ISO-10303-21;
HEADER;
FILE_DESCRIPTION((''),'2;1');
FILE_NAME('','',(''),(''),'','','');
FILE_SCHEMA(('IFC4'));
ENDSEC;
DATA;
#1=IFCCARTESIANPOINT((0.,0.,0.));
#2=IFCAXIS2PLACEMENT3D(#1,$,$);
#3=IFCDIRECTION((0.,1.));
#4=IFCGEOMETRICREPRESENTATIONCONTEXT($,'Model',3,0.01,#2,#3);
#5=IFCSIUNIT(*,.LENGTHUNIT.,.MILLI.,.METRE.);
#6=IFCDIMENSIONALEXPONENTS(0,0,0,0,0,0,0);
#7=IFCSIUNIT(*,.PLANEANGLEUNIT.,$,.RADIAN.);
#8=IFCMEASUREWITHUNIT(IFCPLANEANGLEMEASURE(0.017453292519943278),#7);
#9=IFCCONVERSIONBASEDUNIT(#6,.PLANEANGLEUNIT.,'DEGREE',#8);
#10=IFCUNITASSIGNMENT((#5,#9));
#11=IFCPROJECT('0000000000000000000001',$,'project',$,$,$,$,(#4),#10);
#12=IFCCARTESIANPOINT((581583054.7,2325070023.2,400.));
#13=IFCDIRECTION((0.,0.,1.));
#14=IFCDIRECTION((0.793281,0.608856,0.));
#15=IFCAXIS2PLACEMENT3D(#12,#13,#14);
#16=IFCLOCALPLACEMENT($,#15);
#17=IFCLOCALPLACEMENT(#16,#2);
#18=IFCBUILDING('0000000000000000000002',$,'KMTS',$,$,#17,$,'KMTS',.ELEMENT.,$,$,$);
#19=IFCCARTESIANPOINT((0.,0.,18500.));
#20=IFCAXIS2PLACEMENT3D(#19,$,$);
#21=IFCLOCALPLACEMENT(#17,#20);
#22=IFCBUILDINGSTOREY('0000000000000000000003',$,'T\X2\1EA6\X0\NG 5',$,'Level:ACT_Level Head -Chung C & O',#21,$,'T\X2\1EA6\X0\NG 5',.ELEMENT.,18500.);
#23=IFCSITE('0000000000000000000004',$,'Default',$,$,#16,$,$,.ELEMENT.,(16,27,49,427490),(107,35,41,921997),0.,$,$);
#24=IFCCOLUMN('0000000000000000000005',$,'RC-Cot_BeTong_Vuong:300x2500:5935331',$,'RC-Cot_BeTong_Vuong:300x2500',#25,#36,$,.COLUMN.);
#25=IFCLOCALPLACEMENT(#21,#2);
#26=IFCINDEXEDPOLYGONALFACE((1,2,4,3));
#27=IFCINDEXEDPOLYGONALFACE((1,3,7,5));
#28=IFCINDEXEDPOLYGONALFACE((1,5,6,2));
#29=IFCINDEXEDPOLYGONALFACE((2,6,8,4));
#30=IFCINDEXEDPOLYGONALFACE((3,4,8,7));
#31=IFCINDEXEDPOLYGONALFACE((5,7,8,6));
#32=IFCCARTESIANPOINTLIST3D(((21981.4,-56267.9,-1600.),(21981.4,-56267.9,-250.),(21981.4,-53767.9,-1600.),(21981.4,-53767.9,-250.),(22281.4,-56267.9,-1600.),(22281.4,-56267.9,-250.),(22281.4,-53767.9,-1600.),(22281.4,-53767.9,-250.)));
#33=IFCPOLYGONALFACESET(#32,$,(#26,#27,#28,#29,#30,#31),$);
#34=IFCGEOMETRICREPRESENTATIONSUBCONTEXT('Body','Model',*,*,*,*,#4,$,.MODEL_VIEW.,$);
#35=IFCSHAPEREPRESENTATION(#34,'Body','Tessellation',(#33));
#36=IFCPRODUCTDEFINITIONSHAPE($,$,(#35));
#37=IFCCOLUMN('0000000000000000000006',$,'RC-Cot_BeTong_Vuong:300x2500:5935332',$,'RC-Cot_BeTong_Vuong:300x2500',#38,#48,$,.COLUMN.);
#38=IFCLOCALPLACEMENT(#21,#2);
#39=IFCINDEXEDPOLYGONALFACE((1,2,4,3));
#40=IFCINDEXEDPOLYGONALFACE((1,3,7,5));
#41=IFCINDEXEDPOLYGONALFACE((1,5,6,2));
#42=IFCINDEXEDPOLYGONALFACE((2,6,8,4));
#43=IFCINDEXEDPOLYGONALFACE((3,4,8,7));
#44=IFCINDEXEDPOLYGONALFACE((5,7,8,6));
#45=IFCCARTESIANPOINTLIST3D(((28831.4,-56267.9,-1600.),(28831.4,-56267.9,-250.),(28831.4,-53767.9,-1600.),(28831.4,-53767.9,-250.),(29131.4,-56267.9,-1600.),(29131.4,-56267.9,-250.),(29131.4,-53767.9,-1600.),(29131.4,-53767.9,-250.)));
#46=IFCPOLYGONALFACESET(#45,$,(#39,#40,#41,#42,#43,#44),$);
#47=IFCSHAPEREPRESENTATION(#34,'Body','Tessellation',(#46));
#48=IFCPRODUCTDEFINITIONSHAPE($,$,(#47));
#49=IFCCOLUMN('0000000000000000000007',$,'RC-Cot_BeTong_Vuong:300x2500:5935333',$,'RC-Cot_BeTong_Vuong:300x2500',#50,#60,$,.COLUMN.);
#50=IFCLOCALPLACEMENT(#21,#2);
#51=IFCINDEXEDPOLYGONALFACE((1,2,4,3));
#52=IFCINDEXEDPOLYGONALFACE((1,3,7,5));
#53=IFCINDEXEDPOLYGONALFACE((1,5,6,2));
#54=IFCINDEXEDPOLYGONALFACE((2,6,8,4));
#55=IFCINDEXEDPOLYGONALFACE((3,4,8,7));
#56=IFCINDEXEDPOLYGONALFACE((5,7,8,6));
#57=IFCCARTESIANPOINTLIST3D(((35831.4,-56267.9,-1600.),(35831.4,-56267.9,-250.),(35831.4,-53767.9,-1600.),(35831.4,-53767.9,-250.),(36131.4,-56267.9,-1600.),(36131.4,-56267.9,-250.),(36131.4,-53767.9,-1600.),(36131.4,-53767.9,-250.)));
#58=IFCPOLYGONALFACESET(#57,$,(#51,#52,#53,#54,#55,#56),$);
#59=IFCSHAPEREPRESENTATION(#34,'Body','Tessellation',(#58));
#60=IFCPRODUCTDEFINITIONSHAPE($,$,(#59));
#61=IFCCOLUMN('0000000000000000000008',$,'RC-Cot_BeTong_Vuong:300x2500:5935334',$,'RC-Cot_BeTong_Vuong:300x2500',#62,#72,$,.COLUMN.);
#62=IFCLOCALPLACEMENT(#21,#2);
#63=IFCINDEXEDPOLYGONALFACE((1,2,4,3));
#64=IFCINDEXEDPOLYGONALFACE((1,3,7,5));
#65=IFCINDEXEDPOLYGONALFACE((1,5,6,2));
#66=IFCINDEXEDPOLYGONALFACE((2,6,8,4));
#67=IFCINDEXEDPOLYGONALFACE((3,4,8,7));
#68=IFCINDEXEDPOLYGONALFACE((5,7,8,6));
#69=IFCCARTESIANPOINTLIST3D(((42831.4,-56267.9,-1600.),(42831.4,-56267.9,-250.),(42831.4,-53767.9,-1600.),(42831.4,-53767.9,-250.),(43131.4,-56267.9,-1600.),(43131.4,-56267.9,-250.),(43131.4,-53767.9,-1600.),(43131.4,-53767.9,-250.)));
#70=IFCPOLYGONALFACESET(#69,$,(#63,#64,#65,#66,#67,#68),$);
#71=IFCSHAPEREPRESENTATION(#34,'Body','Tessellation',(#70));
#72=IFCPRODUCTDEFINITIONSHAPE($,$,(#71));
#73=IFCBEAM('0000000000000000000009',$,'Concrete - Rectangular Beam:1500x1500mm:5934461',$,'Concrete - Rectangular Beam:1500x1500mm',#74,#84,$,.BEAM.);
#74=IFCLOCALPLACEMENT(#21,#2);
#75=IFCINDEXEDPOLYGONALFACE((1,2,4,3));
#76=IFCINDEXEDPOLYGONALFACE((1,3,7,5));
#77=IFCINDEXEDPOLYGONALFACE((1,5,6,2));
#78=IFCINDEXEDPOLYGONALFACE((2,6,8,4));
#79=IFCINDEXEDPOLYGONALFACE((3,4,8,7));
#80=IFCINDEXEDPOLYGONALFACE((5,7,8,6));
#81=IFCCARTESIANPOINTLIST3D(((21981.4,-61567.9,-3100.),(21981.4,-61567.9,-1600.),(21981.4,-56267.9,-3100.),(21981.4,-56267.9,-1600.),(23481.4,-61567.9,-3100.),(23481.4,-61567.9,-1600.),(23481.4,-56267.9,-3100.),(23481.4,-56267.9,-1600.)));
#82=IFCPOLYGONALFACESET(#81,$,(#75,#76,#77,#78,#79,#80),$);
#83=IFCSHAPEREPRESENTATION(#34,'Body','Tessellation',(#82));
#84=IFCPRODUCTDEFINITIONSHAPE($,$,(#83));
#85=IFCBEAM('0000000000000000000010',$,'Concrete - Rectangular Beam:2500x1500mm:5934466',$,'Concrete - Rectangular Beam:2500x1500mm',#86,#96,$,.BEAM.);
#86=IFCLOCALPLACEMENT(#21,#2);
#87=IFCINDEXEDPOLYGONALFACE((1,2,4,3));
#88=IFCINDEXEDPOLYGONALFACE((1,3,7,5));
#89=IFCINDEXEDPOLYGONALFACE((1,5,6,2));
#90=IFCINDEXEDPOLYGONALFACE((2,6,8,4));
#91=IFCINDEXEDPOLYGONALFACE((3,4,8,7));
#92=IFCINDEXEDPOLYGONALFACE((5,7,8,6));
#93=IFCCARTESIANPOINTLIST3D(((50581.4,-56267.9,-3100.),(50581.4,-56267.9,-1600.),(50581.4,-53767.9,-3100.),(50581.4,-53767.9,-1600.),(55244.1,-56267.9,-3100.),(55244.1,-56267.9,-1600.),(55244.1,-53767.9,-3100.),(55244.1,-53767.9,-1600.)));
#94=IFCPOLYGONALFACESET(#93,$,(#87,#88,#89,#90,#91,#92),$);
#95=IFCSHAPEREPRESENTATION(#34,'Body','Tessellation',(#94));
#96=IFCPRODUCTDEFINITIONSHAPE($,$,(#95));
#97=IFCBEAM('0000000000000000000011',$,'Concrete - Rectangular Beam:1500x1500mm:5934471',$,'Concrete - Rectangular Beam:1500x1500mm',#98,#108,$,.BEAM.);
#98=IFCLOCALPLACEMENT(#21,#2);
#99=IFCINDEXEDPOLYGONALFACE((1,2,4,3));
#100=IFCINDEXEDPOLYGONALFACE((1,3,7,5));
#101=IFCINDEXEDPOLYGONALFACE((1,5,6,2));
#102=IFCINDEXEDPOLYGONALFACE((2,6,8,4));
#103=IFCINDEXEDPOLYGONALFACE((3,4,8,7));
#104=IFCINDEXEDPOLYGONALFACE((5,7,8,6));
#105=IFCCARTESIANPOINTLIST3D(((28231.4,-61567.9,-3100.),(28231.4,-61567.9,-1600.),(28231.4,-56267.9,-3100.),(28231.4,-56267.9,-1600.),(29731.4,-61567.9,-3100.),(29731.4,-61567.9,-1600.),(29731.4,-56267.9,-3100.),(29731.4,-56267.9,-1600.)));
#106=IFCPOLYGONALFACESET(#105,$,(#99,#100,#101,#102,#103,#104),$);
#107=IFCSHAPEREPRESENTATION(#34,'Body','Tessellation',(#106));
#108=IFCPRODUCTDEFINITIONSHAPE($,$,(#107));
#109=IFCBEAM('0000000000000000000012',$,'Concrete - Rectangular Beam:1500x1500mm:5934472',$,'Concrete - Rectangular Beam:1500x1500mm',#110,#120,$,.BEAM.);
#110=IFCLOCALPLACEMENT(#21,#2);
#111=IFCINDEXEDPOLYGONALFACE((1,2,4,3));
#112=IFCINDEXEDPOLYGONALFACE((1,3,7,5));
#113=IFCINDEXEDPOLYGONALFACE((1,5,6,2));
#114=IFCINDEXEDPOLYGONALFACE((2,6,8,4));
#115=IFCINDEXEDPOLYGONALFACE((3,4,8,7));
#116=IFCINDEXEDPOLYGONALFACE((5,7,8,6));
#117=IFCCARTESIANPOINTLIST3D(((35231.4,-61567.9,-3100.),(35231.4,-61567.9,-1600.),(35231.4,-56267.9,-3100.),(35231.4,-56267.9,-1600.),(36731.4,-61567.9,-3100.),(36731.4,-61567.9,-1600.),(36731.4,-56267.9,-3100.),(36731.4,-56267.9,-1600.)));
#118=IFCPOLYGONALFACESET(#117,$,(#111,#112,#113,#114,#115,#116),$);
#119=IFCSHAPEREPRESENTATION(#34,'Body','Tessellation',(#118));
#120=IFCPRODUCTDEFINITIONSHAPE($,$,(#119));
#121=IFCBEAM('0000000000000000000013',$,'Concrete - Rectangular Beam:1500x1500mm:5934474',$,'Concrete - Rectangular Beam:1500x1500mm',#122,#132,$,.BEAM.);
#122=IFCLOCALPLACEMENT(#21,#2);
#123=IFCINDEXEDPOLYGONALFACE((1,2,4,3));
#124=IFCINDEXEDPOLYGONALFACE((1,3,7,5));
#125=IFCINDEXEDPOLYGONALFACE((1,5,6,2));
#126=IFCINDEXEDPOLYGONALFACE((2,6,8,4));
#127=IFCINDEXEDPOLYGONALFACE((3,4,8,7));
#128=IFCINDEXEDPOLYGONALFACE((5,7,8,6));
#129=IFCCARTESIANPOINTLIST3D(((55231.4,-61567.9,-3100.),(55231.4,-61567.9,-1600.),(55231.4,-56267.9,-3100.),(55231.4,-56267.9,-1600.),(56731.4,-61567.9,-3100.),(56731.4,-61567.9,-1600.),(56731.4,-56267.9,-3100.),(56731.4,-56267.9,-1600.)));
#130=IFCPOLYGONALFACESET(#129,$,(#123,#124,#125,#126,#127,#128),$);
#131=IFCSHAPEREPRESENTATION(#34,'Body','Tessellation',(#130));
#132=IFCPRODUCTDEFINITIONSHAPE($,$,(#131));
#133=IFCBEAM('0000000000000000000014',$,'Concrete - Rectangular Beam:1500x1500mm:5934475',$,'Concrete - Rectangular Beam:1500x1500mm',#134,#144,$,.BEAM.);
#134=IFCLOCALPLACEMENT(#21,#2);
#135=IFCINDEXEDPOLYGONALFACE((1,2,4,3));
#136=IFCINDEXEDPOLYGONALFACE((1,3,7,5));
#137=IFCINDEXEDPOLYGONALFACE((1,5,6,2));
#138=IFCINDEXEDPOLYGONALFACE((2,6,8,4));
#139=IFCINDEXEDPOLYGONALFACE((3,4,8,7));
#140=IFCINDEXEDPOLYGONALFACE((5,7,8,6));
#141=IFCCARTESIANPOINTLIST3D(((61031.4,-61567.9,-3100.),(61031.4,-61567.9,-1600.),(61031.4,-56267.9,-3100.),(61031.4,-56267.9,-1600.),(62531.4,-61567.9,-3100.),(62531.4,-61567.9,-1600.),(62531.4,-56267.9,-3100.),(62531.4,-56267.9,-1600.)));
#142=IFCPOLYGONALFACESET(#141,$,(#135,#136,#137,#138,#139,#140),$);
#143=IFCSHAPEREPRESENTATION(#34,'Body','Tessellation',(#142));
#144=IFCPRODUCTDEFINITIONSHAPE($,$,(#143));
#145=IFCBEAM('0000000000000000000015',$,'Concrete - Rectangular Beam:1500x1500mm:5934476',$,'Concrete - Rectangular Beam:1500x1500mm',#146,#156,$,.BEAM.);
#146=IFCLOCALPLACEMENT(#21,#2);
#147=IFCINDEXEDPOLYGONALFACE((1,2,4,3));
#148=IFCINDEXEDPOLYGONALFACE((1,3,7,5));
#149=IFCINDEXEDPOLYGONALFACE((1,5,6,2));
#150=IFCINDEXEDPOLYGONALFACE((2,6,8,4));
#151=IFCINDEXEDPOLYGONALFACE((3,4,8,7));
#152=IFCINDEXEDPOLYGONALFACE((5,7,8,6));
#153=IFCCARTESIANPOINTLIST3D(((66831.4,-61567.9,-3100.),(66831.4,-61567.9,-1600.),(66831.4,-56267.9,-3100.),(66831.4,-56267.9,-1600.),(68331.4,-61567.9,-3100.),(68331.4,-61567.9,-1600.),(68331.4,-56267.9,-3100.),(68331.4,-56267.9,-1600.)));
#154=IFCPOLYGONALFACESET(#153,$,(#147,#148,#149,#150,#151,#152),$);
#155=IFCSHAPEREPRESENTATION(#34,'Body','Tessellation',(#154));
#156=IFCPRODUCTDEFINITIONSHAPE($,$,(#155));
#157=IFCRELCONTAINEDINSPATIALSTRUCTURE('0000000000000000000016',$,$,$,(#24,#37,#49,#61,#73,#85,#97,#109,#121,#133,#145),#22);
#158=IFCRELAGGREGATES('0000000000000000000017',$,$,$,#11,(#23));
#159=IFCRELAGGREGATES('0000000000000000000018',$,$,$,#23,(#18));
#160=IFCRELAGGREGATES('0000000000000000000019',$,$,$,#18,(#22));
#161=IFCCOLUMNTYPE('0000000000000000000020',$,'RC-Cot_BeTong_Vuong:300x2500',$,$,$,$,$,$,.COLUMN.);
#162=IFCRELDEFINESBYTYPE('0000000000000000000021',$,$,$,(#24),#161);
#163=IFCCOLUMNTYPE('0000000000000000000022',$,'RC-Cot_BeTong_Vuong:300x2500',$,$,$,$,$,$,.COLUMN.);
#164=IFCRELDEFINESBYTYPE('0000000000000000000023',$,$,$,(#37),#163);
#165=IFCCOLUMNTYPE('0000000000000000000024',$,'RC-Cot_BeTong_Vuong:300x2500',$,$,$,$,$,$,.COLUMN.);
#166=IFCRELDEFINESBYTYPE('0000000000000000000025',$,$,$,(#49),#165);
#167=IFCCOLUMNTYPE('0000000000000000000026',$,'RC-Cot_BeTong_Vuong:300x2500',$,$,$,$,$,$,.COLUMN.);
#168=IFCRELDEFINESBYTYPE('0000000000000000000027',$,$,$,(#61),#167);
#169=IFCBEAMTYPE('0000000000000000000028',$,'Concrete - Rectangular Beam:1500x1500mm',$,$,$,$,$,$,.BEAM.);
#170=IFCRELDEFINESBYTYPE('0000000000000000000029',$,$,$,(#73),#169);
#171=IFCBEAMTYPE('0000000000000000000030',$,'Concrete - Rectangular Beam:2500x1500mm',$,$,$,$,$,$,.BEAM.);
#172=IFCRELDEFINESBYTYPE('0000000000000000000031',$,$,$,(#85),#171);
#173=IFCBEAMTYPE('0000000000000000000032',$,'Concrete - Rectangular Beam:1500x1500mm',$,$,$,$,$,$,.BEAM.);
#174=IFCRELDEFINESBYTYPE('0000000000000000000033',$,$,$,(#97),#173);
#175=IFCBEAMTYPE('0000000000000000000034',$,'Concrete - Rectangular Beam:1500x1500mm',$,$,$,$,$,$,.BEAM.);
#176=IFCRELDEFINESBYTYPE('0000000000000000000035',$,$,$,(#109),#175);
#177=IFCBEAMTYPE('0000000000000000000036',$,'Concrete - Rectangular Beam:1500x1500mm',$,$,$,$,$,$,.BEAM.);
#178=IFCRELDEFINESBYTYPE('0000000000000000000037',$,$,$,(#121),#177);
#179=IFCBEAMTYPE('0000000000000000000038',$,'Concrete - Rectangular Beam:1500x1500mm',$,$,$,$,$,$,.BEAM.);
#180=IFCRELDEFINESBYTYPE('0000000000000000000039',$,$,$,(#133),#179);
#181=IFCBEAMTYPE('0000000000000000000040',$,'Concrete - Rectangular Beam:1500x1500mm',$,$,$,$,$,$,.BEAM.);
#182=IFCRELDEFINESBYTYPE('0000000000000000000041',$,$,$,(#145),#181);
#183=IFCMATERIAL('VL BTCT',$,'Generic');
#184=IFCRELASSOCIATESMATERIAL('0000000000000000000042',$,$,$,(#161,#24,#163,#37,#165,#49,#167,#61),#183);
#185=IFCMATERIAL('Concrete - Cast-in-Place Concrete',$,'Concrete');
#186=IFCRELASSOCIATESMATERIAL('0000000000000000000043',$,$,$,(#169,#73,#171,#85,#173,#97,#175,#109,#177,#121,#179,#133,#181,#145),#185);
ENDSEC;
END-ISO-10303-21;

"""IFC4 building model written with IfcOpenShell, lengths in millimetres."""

from ifc_helpers import new_model, entity, si_unit, converted_unit, direction, frame, origin, place, context, subcontext, project, spatial, indexed_curve, outline, extrude, source, transform, mapped, material, type_object, type_shapes, element, save


model = new_model("IFC4")

# Units and contexts
model_context = context("Model", 3, precision=0.01, world=origin(), true_north=direction((0.0, 1.0)))
body_context = subcontext(model_context, "Body", "Model", "MODEL_VIEW")
ifc_project = project(units=[si_unit("LENGTHUNIT", "METRE", prefix="MILLI"), converted_unit("PLANEANGLEUNIT", "DEGREE", entity("IfcPlaneAngleMeasure", 0.017453292519943278), si_unit("PLANEANGLEUNIT", "RADIAN"), dimensions=[0, 0, 0, 0, 0, 0, 0])], contexts=[model_context])

# Site, building, storey
site_placement = place(None, frame((581583054.7, 2325070023.2, 400.0), z_axis=(0.0, 0.0, 1.0), x_axis=(0.793281, 0.608856, 0.0)))
site = spatial("IfcSite", under=ifc_project, at=site_placement, Name="Default", CompositionType="ELEMENT", RefLatitude=(16, 27, 49, 427490), RefLongitude=(107, 35, 41, 921997), RefElevation=0.0)
building_placement = place(site_placement, origin())
building = spatial("IfcBuilding", under=site, at=building_placement, Name="KMTS", LongName="KMTS", CompositionType="ELEMENT")
storey_placement = place(building_placement, frame((0.0, 0.0, 18500.0)))
storey = spatial("IfcBuildingStorey", under=building, at=storey_placement, Name="TẦNG 5", ObjectType="Level:ACT_Level Head -Chung C & O", LongName="TẦNG 5", CompositionType="ELEMENT", Elevation=18500.0)

# Columns
ifc_material_1 = material(Name="VL BTCT", Category="Generic")
column_type_1 = type_object("IfcColumnType", Name="RC-Cot_BeTong_Vuong:300x2500", PredefinedType="COLUMN", material=ifc_material_1)
shared_shape_1 = source(origin(), body_context, "Body", "SweptSolid", [
    extrude(outline(indexed_curve([(-675.0, -1250.0), (675.0, -1250.0), (675.0, 1250.0), (-675.0, 1250.0), (-675.0, -1250.0)], self_intersect=False)), frame((21981.4, -55017.9, 17575.0), z_axis=(1.0, 0.0, 0.0), x_axis=(0.0, 0.0, 1.0)), (0.0, 0.0, 1.0), 300.0),
])
type_shapes(column_type_1, [shared_shape_1])
column_1_placement = place(storey_placement, frame((0.0, 0.0, -18500.0)))
element("IfcColumn", 1, at=column_1_placement, inside=storey, type_object=column_type_1, material=ifc_material_1, Name="RC-Cot_BeTong_Vuong:300x2500:5935331", ObjectType="RC-Cot_BeTong_Vuong:300x2500", PredefinedType="COLUMN", context=body_context, shape_type="MappedRepresentation", body=[
    mapped(shared_shape_1, transform((0.0, 0.0, 0.0), scale=1.0)),
])
column_type_2 = type_object("IfcColumnType", Name="RC-Cot_BeTong_Vuong:300x2500", PredefinedType="COLUMN", material=ifc_material_1)
shared_shape_2 = source(origin(), body_context, "Body", "SweptSolid", [
    extrude(outline(indexed_curve([(-675.0, -1250.0), (675.0, -1250.0), (675.0, 1250.0), (-675.0, 1250.0), (-675.0, -1250.0)], self_intersect=False)), frame((28831.4, -55017.9, 17575.0), z_axis=(1.0, 0.0, 0.0), x_axis=(0.0, 0.0, 1.0)), (0.0, 0.0, 1.0), 300.0),
])
type_shapes(column_type_2, [shared_shape_2])
column_2_placement = place(storey_placement, frame((0.0, 0.0, -18500.0)))
element("IfcColumn", 2, at=column_2_placement, inside=storey, type_object=column_type_2, material=ifc_material_1, Name="RC-Cot_BeTong_Vuong:300x2500:5935332", ObjectType="RC-Cot_BeTong_Vuong:300x2500", PredefinedType="COLUMN", context=body_context, shape_type="MappedRepresentation", body=[
    mapped(shared_shape_2, transform((0.0, 0.0, 0.0), scale=1.0)),
])
column_type_3 = type_object("IfcColumnType", Name="RC-Cot_BeTong_Vuong:300x2500", PredefinedType="COLUMN", material=ifc_material_1)
shared_shape_3 = source(origin(), body_context, "Body", "SweptSolid", [
    extrude(outline(indexed_curve([(-675.0, -1250.0), (675.0, -1250.0), (675.0, 1250.0), (-675.0, 1250.0), (-675.0, -1250.0)], self_intersect=False)), frame((35831.4, -55017.9, 17575.0), z_axis=(1.0, 0.0, 0.0), x_axis=(0.0, 0.0, 1.0)), (0.0, 0.0, 1.0), 300.0),
])
type_shapes(column_type_3, [shared_shape_3])
column_3_placement = place(storey_placement, frame((0.0, 0.0, -18500.0)))
element("IfcColumn", 3, at=column_3_placement, inside=storey, type_object=column_type_3, material=ifc_material_1, Name="RC-Cot_BeTong_Vuong:300x2500:5935333", ObjectType="RC-Cot_BeTong_Vuong:300x2500", PredefinedType="COLUMN", context=body_context, shape_type="MappedRepresentation", body=[
    mapped(shared_shape_3, transform((0.0, 0.0, 0.0), scale=1.0)),
])
column_type_4 = type_object("IfcColumnType", Name="RC-Cot_BeTong_Vuong:300x2500", PredefinedType="COLUMN", material=ifc_material_1)
shared_shape_4 = source(origin(), body_context, "Body", "SweptSolid", [
    extrude(outline(indexed_curve([(-675.0, -1250.0), (675.0, -1250.0), (675.0, 1250.0), (-675.0, 1250.0), (-675.0, -1250.0)], self_intersect=False)), frame((42831.4, -55017.9, 17575.0), z_axis=(1.0, 0.0, 0.0), x_axis=(0.0, 0.0, 1.0)), (0.0, 0.0, 1.0), 300.0),
])
type_shapes(column_type_4, [shared_shape_4])
column_4_placement = place(storey_placement, frame((0.0, 0.0, -18500.0)))
element("IfcColumn", 4, at=column_4_placement, inside=storey, type_object=column_type_4, material=ifc_material_1, Name="RC-Cot_BeTong_Vuong:300x2500:5935334", ObjectType="RC-Cot_BeTong_Vuong:300x2500", PredefinedType="COLUMN", context=body_context, shape_type="MappedRepresentation", body=[
    mapped(shared_shape_4, transform((0.0, 0.0, 0.0), scale=1.0)),
])

# Beams
ifc_material_2 = material(Name="Concrete - Cast-in-Place Concrete", Category="Concrete")
beam_type_1 = type_object("IfcBeamType", Name="Concrete - Rectangular Beam:1500x1500mm", PredefinedType="BEAM", material=ifc_material_2)
shared_shape_5 = source(origin(), body_context, "Body", "SweptSolid", [
    extrude(outline(indexed_curve([(-750.0, -750.0), (750.0, -750.0), (750.0, 750.0), (-750.0, 750.0), (-750.0, -750.0)], self_intersect=False)), frame((22731.4, -61567.9, 16150.0), z_axis=(0.0, 1.0, 0.0), x_axis=(-1.0, 0.0, 0.0)), (0.0, 0.0, 1.0), 5300.0),
])
type_shapes(beam_type_1, [shared_shape_5])
beam_1_placement = place(storey_placement, frame((0.0, 0.0, -18500.0)))
element("IfcBeam", 5, at=beam_1_placement, inside=storey, type_object=beam_type_1, material=ifc_material_2, Name="Concrete - Rectangular Beam:1500x1500mm:5934461", ObjectType="Concrete - Rectangular Beam:1500x1500mm", PredefinedType="BEAM", context=body_context, shape_type="MappedRepresentation", body=[
    mapped(shared_shape_5, transform((0.0, 0.0, 0.0), scale=1.0)),
])
beam_type_2 = type_object("IfcBeamType", Name="Concrete - Rectangular Beam:2500x1500mm", PredefinedType="BEAM", material=ifc_material_2)
shared_shape_6 = source(origin(), body_context, "Body", "SweptSolid", [
    extrude(outline(indexed_curve([(-750.0, -1250.0), (750.0, -1250.0), (750.0, 1250.0), (-750.0, 1250.0), (-750.0, -1250.0)], self_intersect=False)), frame((50581.4, -55017.9, 16150.0), z_axis=(1.0, 0.0, 0.0), x_axis=(0.0, 0.0, -1.0)), (0.0, 0.0, 1.0), 4662.7),
])
type_shapes(beam_type_2, [shared_shape_6])
beam_2_placement = place(storey_placement, frame((0.0, 0.0, -18500.0)))
element("IfcBeam", 6, at=beam_2_placement, inside=storey, type_object=beam_type_2, material=ifc_material_2, Name="Concrete - Rectangular Beam:2500x1500mm:5934466", ObjectType="Concrete - Rectangular Beam:2500x1500mm", PredefinedType="BEAM", context=body_context, shape_type="MappedRepresentation", body=[
    mapped(shared_shape_6, transform((0.0, 0.0, 0.0), scale=1.0)),
])
beam_type_3 = type_object("IfcBeamType", Name="Concrete - Rectangular Beam:1500x1500mm", PredefinedType="BEAM", material=ifc_material_2)
shared_shape_7 = source(origin(), body_context, "Body", "SweptSolid", [
    extrude(outline(indexed_curve([(-750.0, -750.0), (750.0, -750.0), (750.0, 750.0), (-750.0, 750.0), (-750.0, -750.0)], self_intersect=False)), frame((28981.4, -61567.9, 16150.0), z_axis=(0.0, 1.0, 0.0), x_axis=(-1.0, 0.0, 0.0)), (0.0, 0.0, 1.0), 5300.0),
])
type_shapes(beam_type_3, [shared_shape_7])
beam_3_placement = place(storey_placement, frame((0.0, 0.0, -18500.0)))
element("IfcBeam", 7, at=beam_3_placement, inside=storey, type_object=beam_type_3, material=ifc_material_2, Name="Concrete - Rectangular Beam:1500x1500mm:5934471", ObjectType="Concrete - Rectangular Beam:1500x1500mm", PredefinedType="BEAM", context=body_context, shape_type="MappedRepresentation", body=[
    mapped(shared_shape_7, transform((0.0, 0.0, 0.0), scale=1.0)),
])
beam_type_4 = type_object("IfcBeamType", Name="Concrete - Rectangular Beam:1500x1500mm", PredefinedType="BEAM", material=ifc_material_2)
shared_shape_8 = source(origin(), body_context, "Body", "SweptSolid", [
    extrude(outline(indexed_curve([(-750.0, -750.0), (750.0, -750.0), (750.0, 750.0), (-750.0, 750.0), (-750.0, -750.0)], self_intersect=False)), frame((35981.4, -61567.9, 16150.0), z_axis=(0.0, 1.0, 0.0), x_axis=(-1.0, 0.0, 0.0)), (0.0, 0.0, 1.0), 5300.0),
])
type_shapes(beam_type_4, [shared_shape_8])
beam_4_placement = place(storey_placement, frame((0.0, 0.0, -18500.0)))
element("IfcBeam", 8, at=beam_4_placement, inside=storey, type_object=beam_type_4, material=ifc_material_2, Name="Concrete - Rectangular Beam:1500x1500mm:5934472", ObjectType="Concrete - Rectangular Beam:1500x1500mm", PredefinedType="BEAM", context=body_context, shape_type="MappedRepresentation", body=[
    mapped(shared_shape_8, transform((0.0, 0.0, 0.0), scale=1.0)),
])
beam_type_5 = type_object("IfcBeamType", Name="Concrete - Rectangular Beam:1500x1500mm", PredefinedType="BEAM", material=ifc_material_2)
shared_shape_9 = source(origin(), body_context, "Body", "SweptSolid", [
    extrude(outline(indexed_curve([(-750.0, -750.0), (750.0, -750.0), (750.0, 750.0), (-750.0, 750.0), (-750.0, -750.0)], self_intersect=False)), frame((55981.4, -61567.9, 16150.0), z_axis=(0.0, 1.0, 0.0), x_axis=(-1.0, 0.0, 0.0)), (0.0, 0.0, 1.0), 5300.0),
])
type_shapes(beam_type_5, [shared_shape_9])
beam_5_placement = place(storey_placement, frame((0.0, 0.0, -18500.0)))
element("IfcBeam", 9, at=beam_5_placement, inside=storey, type_object=beam_type_5, material=ifc_material_2, Name="Concrete - Rectangular Beam:1500x1500mm:5934474", ObjectType="Concrete - Rectangular Beam:1500x1500mm", PredefinedType="BEAM", context=body_context, shape_type="MappedRepresentation", body=[
    mapped(shared_shape_9, transform((0.0, 0.0, 0.0), scale=1.0)),
])
beam_type_6 = type_object("IfcBeamType", Name="Concrete - Rectangular Beam:1500x1500mm", PredefinedType="BEAM", material=ifc_material_2)
shared_shape_10 = source(origin(), body_context, "Body", "SweptSolid", [
    extrude(outline(indexed_curve([(-750.0, -750.0), (750.0, -750.0), (750.0, 750.0), (-750.0, 750.0), (-750.0, -750.0)], self_intersect=False)), frame((61781.4, -61567.9, 16150.0), z_axis=(0.0, 1.0, 0.0), x_axis=(-1.0, 0.0, 0.0)), (0.0, 0.0, 1.0), 5300.0),
])
type_shapes(beam_type_6, [shared_shape_10])
beam_6_placement = place(storey_placement, frame((0.0, 0.0, -18500.0)))
element("IfcBeam", 10, at=beam_6_placement, inside=storey, type_object=beam_type_6, material=ifc_material_2, Name="Concrete - Rectangular Beam:1500x1500mm:5934475", ObjectType="Concrete - Rectangular Beam:1500x1500mm", PredefinedType="BEAM", context=body_context, shape_type="MappedRepresentation", body=[
    mapped(shared_shape_10, transform((0.0, 0.0, 0.0), scale=1.0)),
])
beam_type_7 = type_object("IfcBeamType", Name="Concrete - Rectangular Beam:1500x1500mm", PredefinedType="BEAM", material=ifc_material_2)
shared_shape_11 = source(origin(), body_context, "Body", "SweptSolid", [
    extrude(outline(indexed_curve([(-750.0, -750.0), (750.0, -750.0), (750.0, 750.0), (-750.0, 750.0), (-750.0, -750.0)], self_intersect=False)), frame((67581.4, -61567.9, 16150.0), z_axis=(0.0, 1.0, 0.0), x_axis=(-1.0, 0.0, 0.0)), (0.0, 0.0, 1.0), 5300.0),
])
type_shapes(beam_type_7, [shared_shape_11])
beam_7_placement = place(storey_placement, frame((0.0, 0.0, -18500.0)))
element("IfcBeam", 11, at=beam_7_placement, inside=storey, type_object=beam_type_7, material=ifc_material_2, Name="Concrete - Rectangular Beam:1500x1500mm:5934476", ObjectType="Concrete - Rectangular Beam:1500x1500mm", PredefinedType="BEAM", context=body_context, shape_type="MappedRepresentation", body=[
    mapped(shared_shape_11, transform((0.0, 0.0, 0.0), scale=1.0)),
])

save(model, "model.ifc")
